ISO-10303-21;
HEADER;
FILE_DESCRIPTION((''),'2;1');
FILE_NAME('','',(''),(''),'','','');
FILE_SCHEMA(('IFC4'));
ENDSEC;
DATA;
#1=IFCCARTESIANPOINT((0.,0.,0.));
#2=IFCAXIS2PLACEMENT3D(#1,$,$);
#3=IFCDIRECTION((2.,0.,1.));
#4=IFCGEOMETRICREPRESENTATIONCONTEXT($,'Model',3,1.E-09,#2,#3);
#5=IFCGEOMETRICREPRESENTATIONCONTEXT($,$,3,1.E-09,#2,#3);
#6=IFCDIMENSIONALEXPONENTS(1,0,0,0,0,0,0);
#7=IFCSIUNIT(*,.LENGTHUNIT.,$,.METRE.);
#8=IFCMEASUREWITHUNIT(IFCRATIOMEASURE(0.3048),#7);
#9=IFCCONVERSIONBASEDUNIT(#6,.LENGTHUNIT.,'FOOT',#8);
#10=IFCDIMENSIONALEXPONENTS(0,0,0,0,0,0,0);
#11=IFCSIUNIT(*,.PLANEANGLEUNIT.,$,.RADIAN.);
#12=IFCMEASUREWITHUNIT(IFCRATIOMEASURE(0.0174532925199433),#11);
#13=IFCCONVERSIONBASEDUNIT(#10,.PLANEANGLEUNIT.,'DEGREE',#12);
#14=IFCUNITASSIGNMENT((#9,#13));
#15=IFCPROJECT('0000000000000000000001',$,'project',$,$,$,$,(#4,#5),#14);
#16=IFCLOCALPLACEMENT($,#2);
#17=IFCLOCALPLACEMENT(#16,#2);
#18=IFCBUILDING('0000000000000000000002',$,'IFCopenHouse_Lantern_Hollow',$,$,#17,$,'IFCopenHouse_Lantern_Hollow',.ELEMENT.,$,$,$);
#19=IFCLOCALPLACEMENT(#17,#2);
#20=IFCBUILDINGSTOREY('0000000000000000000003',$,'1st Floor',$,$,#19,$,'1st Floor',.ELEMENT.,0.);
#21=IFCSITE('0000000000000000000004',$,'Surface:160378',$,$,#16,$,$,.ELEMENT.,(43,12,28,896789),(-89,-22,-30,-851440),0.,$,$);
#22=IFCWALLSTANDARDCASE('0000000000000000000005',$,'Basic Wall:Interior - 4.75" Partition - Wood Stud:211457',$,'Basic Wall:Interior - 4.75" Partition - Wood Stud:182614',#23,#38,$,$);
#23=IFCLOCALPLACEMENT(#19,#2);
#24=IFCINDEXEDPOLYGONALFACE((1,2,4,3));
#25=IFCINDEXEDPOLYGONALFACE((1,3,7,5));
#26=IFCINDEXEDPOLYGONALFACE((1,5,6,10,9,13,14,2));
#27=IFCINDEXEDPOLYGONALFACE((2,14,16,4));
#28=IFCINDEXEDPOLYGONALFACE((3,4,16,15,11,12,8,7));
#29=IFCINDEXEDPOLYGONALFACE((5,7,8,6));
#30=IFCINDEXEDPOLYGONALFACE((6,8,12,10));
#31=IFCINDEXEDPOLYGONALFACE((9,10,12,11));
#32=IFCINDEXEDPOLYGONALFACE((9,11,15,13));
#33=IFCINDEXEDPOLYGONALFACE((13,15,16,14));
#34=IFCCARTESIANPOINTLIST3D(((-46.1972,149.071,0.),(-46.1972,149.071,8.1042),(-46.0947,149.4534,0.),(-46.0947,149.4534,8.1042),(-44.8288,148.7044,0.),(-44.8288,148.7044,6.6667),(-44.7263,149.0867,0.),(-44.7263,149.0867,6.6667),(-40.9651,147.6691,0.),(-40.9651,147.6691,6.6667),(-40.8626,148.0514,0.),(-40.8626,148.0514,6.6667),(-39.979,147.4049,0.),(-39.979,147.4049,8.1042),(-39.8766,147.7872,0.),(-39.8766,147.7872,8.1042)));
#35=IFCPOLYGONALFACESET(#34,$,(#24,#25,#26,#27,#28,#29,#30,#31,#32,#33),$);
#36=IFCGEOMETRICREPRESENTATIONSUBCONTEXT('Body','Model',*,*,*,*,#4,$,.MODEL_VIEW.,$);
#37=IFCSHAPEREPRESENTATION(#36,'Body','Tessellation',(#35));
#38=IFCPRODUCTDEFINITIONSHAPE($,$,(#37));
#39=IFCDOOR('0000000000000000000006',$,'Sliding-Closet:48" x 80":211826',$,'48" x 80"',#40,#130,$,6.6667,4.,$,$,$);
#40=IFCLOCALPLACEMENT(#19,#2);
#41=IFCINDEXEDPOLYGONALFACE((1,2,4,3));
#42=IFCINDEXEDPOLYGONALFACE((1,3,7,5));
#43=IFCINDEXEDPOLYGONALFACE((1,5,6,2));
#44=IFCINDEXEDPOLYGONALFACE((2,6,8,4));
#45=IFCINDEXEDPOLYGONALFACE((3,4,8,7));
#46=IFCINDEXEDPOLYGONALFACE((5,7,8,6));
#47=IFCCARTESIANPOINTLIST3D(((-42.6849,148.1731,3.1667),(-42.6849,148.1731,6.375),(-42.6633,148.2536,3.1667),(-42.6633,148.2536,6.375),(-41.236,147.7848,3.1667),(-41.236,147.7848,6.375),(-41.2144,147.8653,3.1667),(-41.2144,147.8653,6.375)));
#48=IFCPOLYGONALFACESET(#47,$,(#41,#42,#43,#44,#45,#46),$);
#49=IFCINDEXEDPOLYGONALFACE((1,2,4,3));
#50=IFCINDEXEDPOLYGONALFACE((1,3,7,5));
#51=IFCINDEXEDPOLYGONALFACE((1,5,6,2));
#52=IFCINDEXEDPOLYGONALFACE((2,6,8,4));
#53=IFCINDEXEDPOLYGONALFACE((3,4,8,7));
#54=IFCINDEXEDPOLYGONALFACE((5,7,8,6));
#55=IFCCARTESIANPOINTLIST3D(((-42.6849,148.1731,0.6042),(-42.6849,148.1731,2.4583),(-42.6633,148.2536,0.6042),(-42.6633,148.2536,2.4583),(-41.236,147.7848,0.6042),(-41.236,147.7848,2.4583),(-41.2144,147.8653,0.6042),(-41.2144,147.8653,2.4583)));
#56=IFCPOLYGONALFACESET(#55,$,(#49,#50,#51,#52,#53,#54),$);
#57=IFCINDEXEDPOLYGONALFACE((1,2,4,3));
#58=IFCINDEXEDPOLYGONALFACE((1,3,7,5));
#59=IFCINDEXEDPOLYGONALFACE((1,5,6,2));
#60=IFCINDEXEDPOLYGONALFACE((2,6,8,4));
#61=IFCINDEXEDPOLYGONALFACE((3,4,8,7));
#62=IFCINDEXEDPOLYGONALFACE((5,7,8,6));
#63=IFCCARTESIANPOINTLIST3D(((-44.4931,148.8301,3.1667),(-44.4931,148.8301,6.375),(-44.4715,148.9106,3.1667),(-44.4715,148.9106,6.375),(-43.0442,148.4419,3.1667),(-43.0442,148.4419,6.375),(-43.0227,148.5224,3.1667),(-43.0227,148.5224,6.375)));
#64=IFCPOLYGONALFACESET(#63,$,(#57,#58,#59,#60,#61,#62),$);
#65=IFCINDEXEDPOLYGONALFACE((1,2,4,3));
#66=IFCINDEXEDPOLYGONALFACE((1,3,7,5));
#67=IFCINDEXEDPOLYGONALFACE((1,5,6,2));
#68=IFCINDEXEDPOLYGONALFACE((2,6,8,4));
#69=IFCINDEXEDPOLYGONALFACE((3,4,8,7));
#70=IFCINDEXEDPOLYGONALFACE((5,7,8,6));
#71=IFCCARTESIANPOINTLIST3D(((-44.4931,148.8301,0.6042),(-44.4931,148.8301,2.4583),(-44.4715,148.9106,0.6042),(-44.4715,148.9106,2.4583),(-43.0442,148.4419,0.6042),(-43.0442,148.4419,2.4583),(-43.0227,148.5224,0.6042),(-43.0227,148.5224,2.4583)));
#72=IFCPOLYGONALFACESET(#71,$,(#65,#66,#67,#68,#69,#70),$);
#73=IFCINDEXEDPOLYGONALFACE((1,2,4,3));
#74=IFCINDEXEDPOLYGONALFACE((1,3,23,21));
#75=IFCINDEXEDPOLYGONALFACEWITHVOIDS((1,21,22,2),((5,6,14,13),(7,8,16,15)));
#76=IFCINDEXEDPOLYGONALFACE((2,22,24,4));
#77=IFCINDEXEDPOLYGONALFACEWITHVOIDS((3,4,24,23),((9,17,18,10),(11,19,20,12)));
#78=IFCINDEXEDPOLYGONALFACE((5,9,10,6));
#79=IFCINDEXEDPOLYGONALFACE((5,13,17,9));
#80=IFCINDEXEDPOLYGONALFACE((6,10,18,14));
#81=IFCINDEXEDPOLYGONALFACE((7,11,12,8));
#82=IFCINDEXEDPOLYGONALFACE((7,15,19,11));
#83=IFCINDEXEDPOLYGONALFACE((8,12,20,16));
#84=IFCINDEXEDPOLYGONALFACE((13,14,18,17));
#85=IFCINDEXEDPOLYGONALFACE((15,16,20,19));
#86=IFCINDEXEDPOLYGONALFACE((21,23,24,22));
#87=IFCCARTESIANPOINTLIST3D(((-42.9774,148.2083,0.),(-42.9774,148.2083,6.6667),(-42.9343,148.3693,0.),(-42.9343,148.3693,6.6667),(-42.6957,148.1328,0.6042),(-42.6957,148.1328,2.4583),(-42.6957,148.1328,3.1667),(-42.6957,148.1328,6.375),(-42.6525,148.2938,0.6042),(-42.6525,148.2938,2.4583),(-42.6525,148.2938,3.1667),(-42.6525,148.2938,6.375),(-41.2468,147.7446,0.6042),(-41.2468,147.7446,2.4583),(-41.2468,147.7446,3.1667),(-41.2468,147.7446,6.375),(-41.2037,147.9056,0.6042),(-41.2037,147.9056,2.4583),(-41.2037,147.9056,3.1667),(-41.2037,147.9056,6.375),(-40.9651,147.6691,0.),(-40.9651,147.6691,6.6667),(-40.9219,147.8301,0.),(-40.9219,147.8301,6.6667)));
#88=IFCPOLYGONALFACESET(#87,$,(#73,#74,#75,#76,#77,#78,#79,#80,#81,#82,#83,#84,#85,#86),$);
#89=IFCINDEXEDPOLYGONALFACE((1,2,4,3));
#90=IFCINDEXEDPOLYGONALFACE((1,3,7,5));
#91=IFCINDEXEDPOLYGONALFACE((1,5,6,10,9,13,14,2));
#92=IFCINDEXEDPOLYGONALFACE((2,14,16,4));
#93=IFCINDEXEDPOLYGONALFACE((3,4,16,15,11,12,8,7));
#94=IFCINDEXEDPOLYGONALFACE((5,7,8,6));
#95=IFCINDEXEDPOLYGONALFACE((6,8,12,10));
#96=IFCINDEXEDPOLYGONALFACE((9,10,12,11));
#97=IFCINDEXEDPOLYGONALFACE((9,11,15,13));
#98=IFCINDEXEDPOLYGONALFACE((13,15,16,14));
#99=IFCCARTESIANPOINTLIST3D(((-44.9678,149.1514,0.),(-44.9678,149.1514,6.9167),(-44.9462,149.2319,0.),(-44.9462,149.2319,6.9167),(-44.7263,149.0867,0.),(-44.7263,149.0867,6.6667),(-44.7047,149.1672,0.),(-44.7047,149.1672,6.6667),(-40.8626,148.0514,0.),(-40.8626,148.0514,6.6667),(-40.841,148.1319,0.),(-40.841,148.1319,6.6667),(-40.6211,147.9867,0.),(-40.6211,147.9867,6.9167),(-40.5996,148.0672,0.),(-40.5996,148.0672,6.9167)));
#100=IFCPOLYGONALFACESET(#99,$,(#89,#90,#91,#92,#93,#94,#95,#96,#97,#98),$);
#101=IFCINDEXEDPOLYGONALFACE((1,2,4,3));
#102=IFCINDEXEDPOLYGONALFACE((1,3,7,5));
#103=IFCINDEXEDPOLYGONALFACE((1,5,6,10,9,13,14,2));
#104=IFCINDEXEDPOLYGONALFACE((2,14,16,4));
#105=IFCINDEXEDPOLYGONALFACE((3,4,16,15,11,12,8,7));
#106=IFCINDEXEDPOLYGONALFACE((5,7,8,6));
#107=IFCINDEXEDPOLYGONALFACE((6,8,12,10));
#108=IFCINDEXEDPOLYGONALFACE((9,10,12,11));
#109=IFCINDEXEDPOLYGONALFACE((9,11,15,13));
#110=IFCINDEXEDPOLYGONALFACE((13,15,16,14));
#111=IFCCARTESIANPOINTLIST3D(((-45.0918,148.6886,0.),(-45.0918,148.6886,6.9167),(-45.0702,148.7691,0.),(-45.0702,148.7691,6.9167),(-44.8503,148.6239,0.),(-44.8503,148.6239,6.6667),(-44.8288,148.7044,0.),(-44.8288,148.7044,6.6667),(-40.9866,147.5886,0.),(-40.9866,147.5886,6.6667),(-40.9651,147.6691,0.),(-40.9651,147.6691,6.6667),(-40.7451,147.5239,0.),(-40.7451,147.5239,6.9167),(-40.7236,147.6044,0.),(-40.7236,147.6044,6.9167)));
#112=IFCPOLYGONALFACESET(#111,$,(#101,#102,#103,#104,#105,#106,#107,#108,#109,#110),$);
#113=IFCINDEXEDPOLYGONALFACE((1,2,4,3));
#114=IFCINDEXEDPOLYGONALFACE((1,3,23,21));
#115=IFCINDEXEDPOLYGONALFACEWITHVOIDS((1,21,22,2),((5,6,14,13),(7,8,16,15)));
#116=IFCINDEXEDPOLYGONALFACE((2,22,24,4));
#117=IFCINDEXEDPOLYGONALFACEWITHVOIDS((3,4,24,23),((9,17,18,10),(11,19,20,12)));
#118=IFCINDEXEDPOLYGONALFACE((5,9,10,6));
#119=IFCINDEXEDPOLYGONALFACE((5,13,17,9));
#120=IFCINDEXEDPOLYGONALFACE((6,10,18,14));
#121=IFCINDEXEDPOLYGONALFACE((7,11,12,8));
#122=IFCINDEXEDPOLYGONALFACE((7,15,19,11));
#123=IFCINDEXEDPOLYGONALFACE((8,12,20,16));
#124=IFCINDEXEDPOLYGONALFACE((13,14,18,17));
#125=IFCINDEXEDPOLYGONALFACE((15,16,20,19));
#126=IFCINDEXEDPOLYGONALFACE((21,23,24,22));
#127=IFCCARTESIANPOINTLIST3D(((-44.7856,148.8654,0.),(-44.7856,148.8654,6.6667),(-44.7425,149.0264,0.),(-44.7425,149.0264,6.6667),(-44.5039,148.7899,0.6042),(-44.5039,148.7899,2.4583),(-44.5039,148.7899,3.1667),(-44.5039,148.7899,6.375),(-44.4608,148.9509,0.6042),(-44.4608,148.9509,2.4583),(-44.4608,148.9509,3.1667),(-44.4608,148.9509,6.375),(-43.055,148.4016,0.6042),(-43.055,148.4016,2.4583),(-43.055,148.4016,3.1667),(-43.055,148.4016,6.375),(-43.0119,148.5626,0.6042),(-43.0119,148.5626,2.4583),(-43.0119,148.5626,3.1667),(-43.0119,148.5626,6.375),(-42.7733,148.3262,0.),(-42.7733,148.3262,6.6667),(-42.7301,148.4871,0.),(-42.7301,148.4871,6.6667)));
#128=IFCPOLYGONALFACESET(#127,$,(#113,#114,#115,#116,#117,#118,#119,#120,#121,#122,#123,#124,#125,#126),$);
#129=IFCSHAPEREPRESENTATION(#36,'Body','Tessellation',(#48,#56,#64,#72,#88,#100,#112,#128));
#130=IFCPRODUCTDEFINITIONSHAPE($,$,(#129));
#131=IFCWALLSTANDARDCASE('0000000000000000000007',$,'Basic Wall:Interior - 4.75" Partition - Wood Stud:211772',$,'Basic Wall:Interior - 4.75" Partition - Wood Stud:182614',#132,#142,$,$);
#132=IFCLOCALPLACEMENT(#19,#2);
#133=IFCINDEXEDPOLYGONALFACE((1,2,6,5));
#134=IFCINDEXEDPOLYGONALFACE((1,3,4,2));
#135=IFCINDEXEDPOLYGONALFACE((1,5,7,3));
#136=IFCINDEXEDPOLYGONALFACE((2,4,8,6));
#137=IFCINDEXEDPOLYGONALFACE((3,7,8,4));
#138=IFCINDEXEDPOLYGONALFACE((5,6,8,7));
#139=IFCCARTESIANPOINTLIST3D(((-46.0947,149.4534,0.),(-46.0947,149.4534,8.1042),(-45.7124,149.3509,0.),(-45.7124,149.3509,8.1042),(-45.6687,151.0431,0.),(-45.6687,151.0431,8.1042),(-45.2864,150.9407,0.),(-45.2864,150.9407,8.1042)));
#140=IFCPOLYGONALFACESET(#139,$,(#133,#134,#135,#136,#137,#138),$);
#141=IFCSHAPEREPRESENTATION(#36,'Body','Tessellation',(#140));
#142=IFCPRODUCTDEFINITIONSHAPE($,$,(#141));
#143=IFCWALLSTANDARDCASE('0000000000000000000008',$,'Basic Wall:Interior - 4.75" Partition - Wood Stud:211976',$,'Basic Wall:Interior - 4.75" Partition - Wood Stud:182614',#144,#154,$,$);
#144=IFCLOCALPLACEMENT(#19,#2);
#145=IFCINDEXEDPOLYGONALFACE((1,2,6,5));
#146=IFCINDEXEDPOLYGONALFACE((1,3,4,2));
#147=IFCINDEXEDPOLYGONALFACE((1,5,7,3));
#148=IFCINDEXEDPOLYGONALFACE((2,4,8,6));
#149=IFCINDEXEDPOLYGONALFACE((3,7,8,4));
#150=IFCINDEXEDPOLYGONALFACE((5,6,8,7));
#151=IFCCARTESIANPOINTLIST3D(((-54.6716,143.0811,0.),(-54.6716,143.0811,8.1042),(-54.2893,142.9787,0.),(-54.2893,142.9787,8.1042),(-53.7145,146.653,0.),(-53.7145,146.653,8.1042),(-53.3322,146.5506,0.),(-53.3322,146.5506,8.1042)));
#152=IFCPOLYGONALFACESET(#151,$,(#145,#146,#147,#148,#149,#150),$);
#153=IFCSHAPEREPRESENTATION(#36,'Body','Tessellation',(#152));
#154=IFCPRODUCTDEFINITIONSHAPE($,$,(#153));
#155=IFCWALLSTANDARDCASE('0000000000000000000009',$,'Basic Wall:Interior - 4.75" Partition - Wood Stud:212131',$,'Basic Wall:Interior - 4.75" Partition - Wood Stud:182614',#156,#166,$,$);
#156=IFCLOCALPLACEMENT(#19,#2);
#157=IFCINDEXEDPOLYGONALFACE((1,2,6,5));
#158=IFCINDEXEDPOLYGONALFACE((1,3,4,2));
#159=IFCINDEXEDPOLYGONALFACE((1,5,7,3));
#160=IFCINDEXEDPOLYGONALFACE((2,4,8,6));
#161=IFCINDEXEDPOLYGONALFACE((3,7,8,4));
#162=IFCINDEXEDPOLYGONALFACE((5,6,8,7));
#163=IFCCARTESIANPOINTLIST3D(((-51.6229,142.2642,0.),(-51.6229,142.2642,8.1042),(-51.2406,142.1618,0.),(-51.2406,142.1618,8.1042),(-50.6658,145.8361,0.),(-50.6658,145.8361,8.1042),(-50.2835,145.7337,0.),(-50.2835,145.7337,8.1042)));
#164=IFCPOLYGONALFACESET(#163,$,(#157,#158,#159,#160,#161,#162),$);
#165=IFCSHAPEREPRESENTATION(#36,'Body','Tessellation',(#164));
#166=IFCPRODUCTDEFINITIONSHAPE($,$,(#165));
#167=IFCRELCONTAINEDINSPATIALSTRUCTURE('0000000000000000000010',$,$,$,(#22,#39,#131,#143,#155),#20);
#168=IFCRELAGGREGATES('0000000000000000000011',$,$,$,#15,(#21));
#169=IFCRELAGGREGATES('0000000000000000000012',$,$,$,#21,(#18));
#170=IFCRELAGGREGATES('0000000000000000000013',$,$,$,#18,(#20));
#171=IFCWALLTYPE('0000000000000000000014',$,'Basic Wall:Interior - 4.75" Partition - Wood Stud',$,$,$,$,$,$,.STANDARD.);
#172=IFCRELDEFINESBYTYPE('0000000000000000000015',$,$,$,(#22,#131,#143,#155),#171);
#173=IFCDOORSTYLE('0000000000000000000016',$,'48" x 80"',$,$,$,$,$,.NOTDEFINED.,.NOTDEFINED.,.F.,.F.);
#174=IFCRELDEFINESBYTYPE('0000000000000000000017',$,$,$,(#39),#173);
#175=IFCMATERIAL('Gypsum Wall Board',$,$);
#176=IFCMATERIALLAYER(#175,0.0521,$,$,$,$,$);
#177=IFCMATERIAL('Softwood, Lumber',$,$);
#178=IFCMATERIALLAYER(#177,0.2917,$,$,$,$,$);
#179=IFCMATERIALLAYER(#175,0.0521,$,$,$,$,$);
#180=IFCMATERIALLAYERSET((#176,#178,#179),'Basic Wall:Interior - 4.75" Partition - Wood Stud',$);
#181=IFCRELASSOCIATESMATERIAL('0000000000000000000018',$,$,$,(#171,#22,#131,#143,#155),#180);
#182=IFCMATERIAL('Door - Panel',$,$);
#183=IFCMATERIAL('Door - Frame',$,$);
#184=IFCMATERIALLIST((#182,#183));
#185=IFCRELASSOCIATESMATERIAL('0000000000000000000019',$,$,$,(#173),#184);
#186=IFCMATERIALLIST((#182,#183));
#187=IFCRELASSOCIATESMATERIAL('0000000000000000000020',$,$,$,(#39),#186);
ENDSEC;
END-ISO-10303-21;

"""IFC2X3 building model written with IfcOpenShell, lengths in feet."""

from ifc_helpers import new_model, entity, si_unit, converted_unit, direction, frame, frame_2d, origin, origin_2d_with_axis, place, context, subcontext, project, spatial, polyline, rectangle, outline, extrude, source, transform, mapped, material, material_list, layer, layer_set, layer_usage, type_object, type_shapes, element, fill, save


model = new_model("IFC2X3")

# Units and contexts
model_context = context("Model", 3, precision=1e-09, world=origin(), true_north=direction((2.0, 0.0, 1.0)))
context_of_model = context(None, 3, precision=1e-09, world=origin(), true_north=direction((2.0, 0.0, 1.0)))
body_context = subcontext(model_context, "Body", "Model", "MODEL_VIEW")
ifc_project = project(units=[converted_unit("LENGTHUNIT", "FOOT", entity("IfcRatioMeasure", 0.3048), si_unit("LENGTHUNIT", "METRE"), dimensions=[1, 0, 0, 0, 0, 0, 0]), converted_unit("PLANEANGLEUNIT", "DEGREE", entity("IfcRatioMeasure", 0.0174532925199433), si_unit("PLANEANGLEUNIT", "RADIAN"), dimensions=[0, 0, 0, 0, 0, 0, 0])], contexts=[model_context, context_of_model])

# Site, building, storey
site_placement = place(None, origin())
site = spatial("IfcSite", under=ifc_project, at=site_placement, Name="Surface:160378", CompositionType="ELEMENT", RefLatitude=(43, 12, 28, 896789), RefLongitude=(-89, -22, -30, -851440), RefElevation=0.0)
building_placement = place(site_placement, origin())
building = spatial("IfcBuilding", under=site, at=building_placement, Name="IFCopenHouse_Lantern_Hollow", LongName="IFCopenHouse_Lantern_Hollow", CompositionType="ELEMENT")
storey_placement = place(building_placement, origin())
storey = spatial("IfcBuildingStorey", under=building, at=storey_placement, Name="1st Floor", LongName="1st Floor", CompositionType="ELEMENT", Elevation=0.0)

# Shared definitions
ifc_material_1 = material(Name="Gypsum Wall Board")
ifc_layer_1 = layer(ifc_material_1, 0.0521)
ifc_material_2 = material(Name="Softwood, Lumber")
ifc_layer_2 = layer(ifc_material_2, 0.2917)
ifc_layer_3 = layer(ifc_material_1, 0.0521)
ifc_layer_set_1 = layer_set([ifc_layer_1, ifc_layer_2, ifc_layer_3], Name="Basic Wall:Interior - 4.75\" Partition - Wood Stud")
wall_type_1 = type_object("IfcWallType", Name="Basic Wall:Interior - 4.75\" Partition - Wood Stud", PredefinedType="STANDARD", material=ifc_layer_set_1)

# Shared definitions
ifc_material_3 = material(Name="Door - Panel")
ifc_material_4 = material(Name="Door - Frame")

# Wall, opening, door
ifc_layer_usage_1 = layer_usage(ifc_layer_set_1, "AXIS2", "NEGATIVE", 0.1979)
wall_1_placement = place(storey_placement, frame((-46.1459, 149.2622, 0.0), z_axis=(0.0, 0.0, 1.0), x_axis=(0.965926, -0.258819, 0.0)))
wall_1 = element("IfcWallStandardCase", 1, at=wall_1_placement, inside=storey, type_object=wall_type_1, material=ifc_layer_usage_1, Name="Basic Wall:Interior - 4.75\" Partition - Wood Stud:211457", ObjectType="Basic Wall:Interior - 4.75\" Partition - Wood Stud:182614", context=body_context, shape_type="SweptSolid", body=[
    extrude(rectangle(XDim=6.4375, YDim=0.3958, at=frame_2d((3.2187, 0.0), x_axis=(-1.0, 0.0))), origin(), (0.0, 0.0, 1.0), 8.1042),
])
opening_1_placement = place(wall_1_placement, frame((5.4167, 0.1979, 0.0)))
opening_1 = element("IfcOpeningElement", 2, at=opening_1_placement, cuts=wall_1, ObjectType="Opening", context=body_context, shape_type="SweptSolid", body=[
    extrude(rectangle(XDim=6.6667, YDim=4.0, at=frame_2d((3.3333, 2.0), x_axis=(-1.0, 0.0))), frame((0.0, 0.0, 0.0), z_axis=(0.0, -1.0, 0.0), x_axis=(0.0, 0.0, 1.0)), (0.0, 0.0, 1.0), 0.3958),
])
ifc_material_list_1 = material_list([ifc_material_3, ifc_material_4])
ifc_material_list_2 = material_list([ifc_material_3, ifc_material_4])
door_style_1 = type_object("IfcDoorStyle", Name="48\" x 80\"", ConstructionType="NOTDEFINED", OperationType="NOTDEFINED", ParameterTakesPrecedence=False, Sizeable=False, material=ifc_material_list_2)
shared_shape_1 = source(origin(), body_context, "Body", "SweptSolid", [
    extrude(rectangle(XDim=0.0833, YDim=1.5, at=origin_2d_with_axis()), frame((1.0417, 0.3125, 3.1667), z_axis=(0.0, 0.0, 1.0), x_axis=(0.0, 1.0, 0.0)), (0.0, 0.0, 1.0), 3.2083),
    extrude(rectangle(XDim=0.0833, YDim=1.5, at=origin_2d_with_axis()), frame((1.0417, 0.3125, 0.6042), z_axis=(0.0, 0.0, 1.0), x_axis=(0.0, 1.0, 0.0)), (0.0, 0.0, 1.0), 1.8542),
    extrude(rectangle(XDim=0.0833, YDim=1.5, at=frame_2d((0.0, 0.0), x_axis=(1.0, 0.0))), frame((2.9583, 0.1458, 3.1667), z_axis=(0.0, 0.0, 1.0), x_axis=(0.0, -1.0, 0.0)), (0.0, 0.0, 1.0), 3.2083),
    extrude(rectangle(XDim=0.0833, YDim=1.5, at=frame_2d((0.0, 0.0), x_axis=(1.0, 0.0))), frame((2.9583, 0.1458, 0.6042), z_axis=(0.0, 0.0, 1.0), x_axis=(0.0, -1.0, 0.0)), (0.0, 0.0, 1.0), 1.8542),
    extrude(outline(polyline([(-3.3333, -1.0417), (3.3333, -1.0417), (3.3333, 1.0417), (-3.3333, 1.0417), (-3.3333, -1.0417)]), holes=[polyline([(2.7292, 0.75), (2.7292, -0.75), (0.875, -0.75), (0.875, 0.75), (2.7292, 0.75)]), polyline([(0.1667, 0.75), (0.1667, -0.75), (-3.0417, -0.75), (-3.0417, 0.75), (0.1667, 0.75)])]), frame((1.0417, 0.2292, 3.3333), z_axis=(0.0, 1.0, 0.0), x_axis=(0.0, 0.0, -1.0)), (0.0, 0.0, 1.0), 0.1667),
    extrude(outline(polyline([(-3.3958, -2.25), (3.5208, -2.25), (3.5208, 2.25), (-3.3958, 2.25), (-3.3958, 2.0), (3.2708, 2.0), (3.2708, -2.0), (-3.3958, -2.0), (-3.3958, -2.25)])), frame((2.0, -0.0833, 3.3958), z_axis=(0.0, 1.0, 0.0), x_axis=(0.0, 0.0, 1.0)), (0.0, 0.0, 1.0), 0.0833),
    extrude(outline(polyline([(-2.25, -3.3958), (-2.0, -3.3958), (-2.0, 3.2708), (2.0, 3.2708), (2.0, -3.3958), (2.25, -3.3958), (2.25, 3.5208), (-2.25, 3.5208), (-2.25, -3.3958)])), frame((2.0, 0.3958, 3.3958), z_axis=(0.0, 1.0, 0.0), x_axis=(-1.0, 0.0, 0.0)), (0.0, 0.0, 1.0), 0.0833),
    extrude(outline(polyline([(-1.0417, -3.3333), (1.0417, -3.3333), (1.0417, 3.3333), (-1.0417, 3.3333), (-1.0417, -3.3333)]), holes=[polyline([(0.75, 0.1667), (0.75, -3.0417), (-0.75, -3.0417), (-0.75, 0.1667), (0.75, 0.1667)]), polyline([(0.75, 2.7292), (0.75, 0.875), (-0.75, 0.875), (-0.75, 2.7292), (0.75, 2.7292)])]), frame((2.9583, 0.0625, 3.3333), z_axis=(0.0, 1.0, 0.0), x_axis=(1.0, 0.0, 0.0)), (0.0, 0.0, 1.0), 0.1667),
])
type_shapes(door_style_1, [shared_shape_1])
door_1_placement = place(storey_placement, frame((-40.8626, 148.0514, 0.0), z_axis=(0.0, 0.0, 1.0), x_axis=(-0.965926, 0.258819, 0.0)))
door_1 = element("IfcDoor", 3, at=door_1_placement, inside=storey, type_object=door_style_1, material=ifc_material_list_1, Name="Sliding-Closet:48\" x 80\":211826", ObjectType="48\" x 80\"", OverallHeight=6.6667, OverallWidth=4.0, context=body_context, shape_type="MappedRepresentation", body=[
    mapped(shared_shape_1, transform((0.0, 0.0, 0.0), scale=1.0)),
])
fill(opening_1, door_1)

# Walls
ifc_layer_usage_2 = layer_usage(ifc_layer_set_1, "AXIS2", "NEGATIVE", 0.1979)
wall_2_placement = place(storey_placement, frame((-45.9035, 149.4022, 0.0), z_axis=(0.0, 0.0, 1.0), x_axis=(0.258819, 0.965926, 0.0)))
element("IfcWallStandardCase", 4, at=wall_2_placement, inside=storey, type_object=wall_type_1, material=ifc_layer_usage_2, Name="Basic Wall:Interior - 4.75\" Partition - Wood Stud:211772", ObjectType="Basic Wall:Interior - 4.75\" Partition - Wood Stud:182614", context=body_context, shape_type="SweptSolid", body=[
    extrude(rectangle(XDim=1.6458, YDim=0.3958, at=frame_2d((0.8229, 0.0), x_axis=(-1.0, 0.0))), origin(), (0.0, 0.0, 1.0), 8.1042),
])
ifc_layer_usage_3 = layer_usage(ifc_layer_set_1, "AXIS2", "NEGATIVE", 0.1979)
wall_3_placement = place(storey_placement, frame((-54.4805, 143.0299, 0.0), z_axis=(0.0, 0.0, 1.0), x_axis=(0.258819, 0.965926, 0.0)))
element("IfcWallStandardCase", 5, at=wall_3_placement, inside=storey, type_object=wall_type_1, material=ifc_layer_usage_3, Name="Basic Wall:Interior - 4.75\" Partition - Wood Stud:211976", ObjectType="Basic Wall:Interior - 4.75\" Partition - Wood Stud:182614", context=body_context, shape_type="SweptSolid", body=[
    extrude(rectangle(XDim=3.6979, YDim=0.3958, at=frame_2d((1.849, 0.0), x_axis=(-1.0, 0.0))), origin(), (0.0, 0.0, 1.0), 8.1042),
])
ifc_layer_usage_4 = layer_usage(ifc_layer_set_1, "AXIS2", "POSITIVE", -0.1979)
wall_4_placement = place(storey_placement, frame((-51.4318, 142.213, 0.0), z_axis=(0.0, 0.0, 1.0), x_axis=(0.258819, 0.965926, 0.0)))
element("IfcWallStandardCase", 6, at=wall_4_placement, inside=storey, type_object=wall_type_1, material=ifc_layer_usage_4, Name="Basic Wall:Interior - 4.75\" Partition - Wood Stud:212131", ObjectType="Basic Wall:Interior - 4.75\" Partition - Wood Stud:182614", context=body_context, shape_type="SweptSolid", body=[
    extrude(rectangle(XDim=3.6979, YDim=0.3958, at=frame_2d((1.849, 0.0), x_axis=(-1.0, 0.0))), origin(), (0.0, 0.0, 1.0), 8.1042),
])

save(model, "model.ifc")
